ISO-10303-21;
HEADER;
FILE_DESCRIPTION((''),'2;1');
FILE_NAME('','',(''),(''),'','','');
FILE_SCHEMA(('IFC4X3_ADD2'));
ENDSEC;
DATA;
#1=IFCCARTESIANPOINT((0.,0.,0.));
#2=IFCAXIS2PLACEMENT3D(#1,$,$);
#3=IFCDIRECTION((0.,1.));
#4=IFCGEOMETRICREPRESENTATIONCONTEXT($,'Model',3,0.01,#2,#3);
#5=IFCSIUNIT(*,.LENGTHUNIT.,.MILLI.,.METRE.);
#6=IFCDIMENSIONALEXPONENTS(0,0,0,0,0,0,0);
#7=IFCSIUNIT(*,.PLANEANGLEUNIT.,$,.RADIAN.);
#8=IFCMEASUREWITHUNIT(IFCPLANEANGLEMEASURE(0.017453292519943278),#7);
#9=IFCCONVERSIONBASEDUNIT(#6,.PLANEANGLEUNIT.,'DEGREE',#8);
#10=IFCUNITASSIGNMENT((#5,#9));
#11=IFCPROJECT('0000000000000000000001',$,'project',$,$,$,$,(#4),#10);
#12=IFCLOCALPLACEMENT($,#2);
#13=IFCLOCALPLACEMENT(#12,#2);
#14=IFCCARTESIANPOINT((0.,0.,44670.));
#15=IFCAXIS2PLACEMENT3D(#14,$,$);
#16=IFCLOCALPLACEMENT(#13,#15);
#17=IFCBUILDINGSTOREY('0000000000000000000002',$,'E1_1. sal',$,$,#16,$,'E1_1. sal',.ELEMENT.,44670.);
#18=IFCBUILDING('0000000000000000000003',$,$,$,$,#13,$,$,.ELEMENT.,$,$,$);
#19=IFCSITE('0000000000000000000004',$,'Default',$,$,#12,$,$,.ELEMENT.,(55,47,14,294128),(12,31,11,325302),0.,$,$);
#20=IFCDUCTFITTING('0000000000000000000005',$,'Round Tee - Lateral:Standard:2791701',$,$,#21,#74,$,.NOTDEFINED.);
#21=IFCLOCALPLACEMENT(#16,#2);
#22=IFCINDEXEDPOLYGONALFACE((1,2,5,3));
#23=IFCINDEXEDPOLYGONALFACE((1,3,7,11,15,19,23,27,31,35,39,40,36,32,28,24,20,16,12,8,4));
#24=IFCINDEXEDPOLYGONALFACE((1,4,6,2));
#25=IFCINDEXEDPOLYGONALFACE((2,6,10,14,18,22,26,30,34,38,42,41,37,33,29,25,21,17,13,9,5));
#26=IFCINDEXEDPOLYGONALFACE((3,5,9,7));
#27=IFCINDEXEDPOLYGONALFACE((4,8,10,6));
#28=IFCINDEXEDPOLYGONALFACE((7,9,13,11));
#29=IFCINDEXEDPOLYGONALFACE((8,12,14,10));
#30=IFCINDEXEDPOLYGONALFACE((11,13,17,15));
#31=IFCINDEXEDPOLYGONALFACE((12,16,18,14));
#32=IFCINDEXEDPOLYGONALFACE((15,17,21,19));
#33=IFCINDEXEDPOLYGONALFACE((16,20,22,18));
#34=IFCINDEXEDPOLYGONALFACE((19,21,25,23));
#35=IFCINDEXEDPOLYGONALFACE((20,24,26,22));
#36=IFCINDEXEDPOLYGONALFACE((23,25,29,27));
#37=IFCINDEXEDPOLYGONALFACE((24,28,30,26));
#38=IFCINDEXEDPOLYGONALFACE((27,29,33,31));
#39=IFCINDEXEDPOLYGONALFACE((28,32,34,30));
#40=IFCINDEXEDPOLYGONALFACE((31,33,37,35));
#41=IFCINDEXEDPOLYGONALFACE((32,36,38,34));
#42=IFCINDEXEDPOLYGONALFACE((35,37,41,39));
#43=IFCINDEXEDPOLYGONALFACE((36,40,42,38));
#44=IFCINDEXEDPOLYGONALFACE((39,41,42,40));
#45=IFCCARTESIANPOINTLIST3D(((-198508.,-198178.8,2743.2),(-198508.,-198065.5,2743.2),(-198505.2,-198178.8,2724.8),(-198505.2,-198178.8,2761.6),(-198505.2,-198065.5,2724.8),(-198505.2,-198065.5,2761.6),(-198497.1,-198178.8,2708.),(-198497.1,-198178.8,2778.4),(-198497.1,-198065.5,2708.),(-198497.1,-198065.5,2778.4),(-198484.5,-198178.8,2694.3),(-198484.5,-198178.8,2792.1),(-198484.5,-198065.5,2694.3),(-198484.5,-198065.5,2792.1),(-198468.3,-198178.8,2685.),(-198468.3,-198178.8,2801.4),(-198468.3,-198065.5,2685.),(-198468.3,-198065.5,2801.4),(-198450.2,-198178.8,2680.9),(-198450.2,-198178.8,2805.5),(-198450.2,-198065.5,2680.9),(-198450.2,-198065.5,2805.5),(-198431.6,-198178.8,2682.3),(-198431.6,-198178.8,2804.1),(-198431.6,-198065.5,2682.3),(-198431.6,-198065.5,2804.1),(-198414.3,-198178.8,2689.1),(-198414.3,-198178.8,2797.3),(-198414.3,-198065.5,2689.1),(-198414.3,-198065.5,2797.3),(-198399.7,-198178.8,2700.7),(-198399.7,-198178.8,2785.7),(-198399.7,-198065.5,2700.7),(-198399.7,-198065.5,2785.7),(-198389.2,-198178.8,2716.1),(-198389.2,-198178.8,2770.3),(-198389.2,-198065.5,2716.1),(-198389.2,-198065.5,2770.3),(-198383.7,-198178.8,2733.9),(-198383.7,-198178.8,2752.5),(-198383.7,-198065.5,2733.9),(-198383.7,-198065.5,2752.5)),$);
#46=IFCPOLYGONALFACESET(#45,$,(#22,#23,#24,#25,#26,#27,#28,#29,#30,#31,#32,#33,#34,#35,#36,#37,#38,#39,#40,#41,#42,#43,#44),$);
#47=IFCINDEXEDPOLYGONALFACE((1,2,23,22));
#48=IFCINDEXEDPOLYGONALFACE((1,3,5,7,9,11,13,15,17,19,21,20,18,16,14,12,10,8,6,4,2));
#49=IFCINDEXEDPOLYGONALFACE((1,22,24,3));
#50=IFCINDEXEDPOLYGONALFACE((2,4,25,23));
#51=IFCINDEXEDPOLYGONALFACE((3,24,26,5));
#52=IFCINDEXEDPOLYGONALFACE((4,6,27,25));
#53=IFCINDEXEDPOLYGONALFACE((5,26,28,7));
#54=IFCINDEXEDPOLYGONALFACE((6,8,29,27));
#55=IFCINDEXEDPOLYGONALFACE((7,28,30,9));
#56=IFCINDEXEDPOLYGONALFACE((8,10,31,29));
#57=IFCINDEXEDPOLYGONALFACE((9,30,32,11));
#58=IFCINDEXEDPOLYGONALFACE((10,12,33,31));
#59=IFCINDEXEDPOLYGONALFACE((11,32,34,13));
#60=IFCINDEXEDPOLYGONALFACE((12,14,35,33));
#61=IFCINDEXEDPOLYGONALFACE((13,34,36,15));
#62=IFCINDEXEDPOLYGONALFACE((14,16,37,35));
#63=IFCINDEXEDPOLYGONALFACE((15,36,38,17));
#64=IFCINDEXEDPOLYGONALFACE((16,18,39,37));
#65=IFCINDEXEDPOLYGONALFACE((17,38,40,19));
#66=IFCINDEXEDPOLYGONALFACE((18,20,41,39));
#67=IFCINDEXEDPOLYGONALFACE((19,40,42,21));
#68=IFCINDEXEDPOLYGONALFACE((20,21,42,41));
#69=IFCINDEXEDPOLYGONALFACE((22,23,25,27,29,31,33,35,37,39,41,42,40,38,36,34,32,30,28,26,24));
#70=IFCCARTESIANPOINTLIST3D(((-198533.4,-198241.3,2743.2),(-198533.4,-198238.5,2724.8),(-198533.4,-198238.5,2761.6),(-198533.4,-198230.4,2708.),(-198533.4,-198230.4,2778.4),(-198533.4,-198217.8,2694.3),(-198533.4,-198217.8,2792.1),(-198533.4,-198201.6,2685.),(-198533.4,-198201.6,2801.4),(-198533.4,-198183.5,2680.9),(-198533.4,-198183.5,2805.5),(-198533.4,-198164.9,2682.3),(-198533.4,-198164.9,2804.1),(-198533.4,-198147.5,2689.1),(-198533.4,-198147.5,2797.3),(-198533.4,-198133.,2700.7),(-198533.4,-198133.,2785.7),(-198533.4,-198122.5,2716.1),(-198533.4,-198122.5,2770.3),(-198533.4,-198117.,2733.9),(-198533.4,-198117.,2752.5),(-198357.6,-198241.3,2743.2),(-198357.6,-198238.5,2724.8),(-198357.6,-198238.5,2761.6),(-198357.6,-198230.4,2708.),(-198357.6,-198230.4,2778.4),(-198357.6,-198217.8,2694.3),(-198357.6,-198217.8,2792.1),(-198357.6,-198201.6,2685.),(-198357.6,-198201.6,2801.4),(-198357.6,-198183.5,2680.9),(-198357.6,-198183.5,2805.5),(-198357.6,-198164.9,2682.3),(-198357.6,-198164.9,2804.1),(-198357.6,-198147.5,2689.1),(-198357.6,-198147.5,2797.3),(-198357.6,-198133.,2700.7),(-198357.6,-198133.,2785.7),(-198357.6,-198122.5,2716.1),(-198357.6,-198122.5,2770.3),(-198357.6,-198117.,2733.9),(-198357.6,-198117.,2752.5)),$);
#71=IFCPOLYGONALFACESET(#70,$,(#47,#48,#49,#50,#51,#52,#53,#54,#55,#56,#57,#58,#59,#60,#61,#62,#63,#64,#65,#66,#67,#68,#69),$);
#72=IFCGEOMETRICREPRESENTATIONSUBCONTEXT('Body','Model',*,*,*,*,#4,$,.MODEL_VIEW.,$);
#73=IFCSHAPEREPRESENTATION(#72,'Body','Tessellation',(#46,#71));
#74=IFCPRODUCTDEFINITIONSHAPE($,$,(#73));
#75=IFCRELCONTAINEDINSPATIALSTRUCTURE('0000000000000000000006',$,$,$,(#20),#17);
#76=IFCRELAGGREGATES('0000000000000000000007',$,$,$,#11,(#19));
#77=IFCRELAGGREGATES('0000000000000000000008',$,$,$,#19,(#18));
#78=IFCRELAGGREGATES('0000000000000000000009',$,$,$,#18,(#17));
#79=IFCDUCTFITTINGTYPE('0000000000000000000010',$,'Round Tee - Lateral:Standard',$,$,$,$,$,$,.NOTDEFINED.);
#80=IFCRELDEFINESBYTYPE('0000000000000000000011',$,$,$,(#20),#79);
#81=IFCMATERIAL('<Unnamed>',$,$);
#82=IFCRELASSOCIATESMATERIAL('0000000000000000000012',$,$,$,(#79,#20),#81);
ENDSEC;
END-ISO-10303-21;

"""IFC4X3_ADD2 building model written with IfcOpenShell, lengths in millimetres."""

from ifc_helpers import new_model, entity, si_unit, converted_unit, direction, frame, frame_2d, origin, place, context, subcontext, project, spatial, circle, extrude, source, transform, mapped, material, type_object, type_shapes, element, save


model = new_model("IFC4X3_ADD2")

# Units and contexts
model_context = context("Model", 3, precision=0.01, world=origin(), true_north=direction((0.0, 1.0)))
body_context = subcontext(model_context, "Body", "Model", "MODEL_VIEW")
ifc_project = project(units=[si_unit("LENGTHUNIT", "METRE", prefix="MILLI"), converted_unit("PLANEANGLEUNIT", "DEGREE", entity("IfcPlaneAngleMeasure", 0.017453292519943278), si_unit("PLANEANGLEUNIT", "RADIAN"), dimensions=[0, 0, 0, 0, 0, 0, 0])], contexts=[model_context])

# Site, building, storey
site_placement = place(None, origin())
site = spatial("IfcSite", under=ifc_project, at=site_placement, Name="Default", CompositionType="ELEMENT", RefLatitude=(55, 47, 14, 294128), RefLongitude=(12, 31, 11, 325302), RefElevation=0.0)
building_placement = place(site_placement, origin())
building = spatial("IfcBuilding", under=site, at=building_placement, CompositionType="ELEMENT")
storey_placement = place(building_placement, frame((0.0, 0.0, 44670.0)))
storey = spatial("IfcBuildingStorey", under=building, at=storey_placement, Name="E1_1. sal", LongName="E1_1. sal", CompositionType="ELEMENT", Elevation=44670.0)

# Shared definitions
ifc_material_1 = material(Name="<Unnamed>")

# Duct fitting
duct_fitting_type = type_object("IfcDuctFittingType", Name="Round Tee - Lateral:Standard", PredefinedType="NOTDEFINED", material=ifc_material_1)
shared_shape_1 = source(origin(), body_context, "Body", "SweptSolid", [
    extrude(circle(Radius=62.5, at=frame_2d((0.0, 0.0), x_axis=(1.0, 0.0))), frame((0.0, -113.3, 0.0), z_axis=(0.0, 1.0, 0.0), x_axis=(1.0, 0.0, 0.0)), (0.0, 0.0, 1.0), 113.3),
    extrude(circle(Radius=62.5, at=frame_2d((0.0, 0.0), x_axis=(1.0, 0.0))), frame((-87.9, 0.0, 0.0), z_axis=(1.0, 0.0, 0.0), x_axis=(0.0, 1.0, 0.0)), (0.0, 0.0, 1.0), 175.8),
])
type_shapes(duct_fitting_type, [shared_shape_1])
duct_fitting_placement = place(storey_placement, frame((-198445.5, -198178.8, 2743.2), z_axis=(0.0, 0.0, 1.0), x_axis=(-1.0, 0.0, 0.0)))
element("IfcDuctFitting", 1, at=duct_fitting_placement, inside=storey, type_object=duct_fitting_type, material=ifc_material_1, Name="Round Tee - Lateral:Standard:2791701", PredefinedType="NOTDEFINED", context=body_context, shape_type="MappedRepresentation", body=[
    mapped(shared_shape_1, transform((0.0, 0.0, 0.0), scale=1.0)),
])

save(model, "model.ifc")
